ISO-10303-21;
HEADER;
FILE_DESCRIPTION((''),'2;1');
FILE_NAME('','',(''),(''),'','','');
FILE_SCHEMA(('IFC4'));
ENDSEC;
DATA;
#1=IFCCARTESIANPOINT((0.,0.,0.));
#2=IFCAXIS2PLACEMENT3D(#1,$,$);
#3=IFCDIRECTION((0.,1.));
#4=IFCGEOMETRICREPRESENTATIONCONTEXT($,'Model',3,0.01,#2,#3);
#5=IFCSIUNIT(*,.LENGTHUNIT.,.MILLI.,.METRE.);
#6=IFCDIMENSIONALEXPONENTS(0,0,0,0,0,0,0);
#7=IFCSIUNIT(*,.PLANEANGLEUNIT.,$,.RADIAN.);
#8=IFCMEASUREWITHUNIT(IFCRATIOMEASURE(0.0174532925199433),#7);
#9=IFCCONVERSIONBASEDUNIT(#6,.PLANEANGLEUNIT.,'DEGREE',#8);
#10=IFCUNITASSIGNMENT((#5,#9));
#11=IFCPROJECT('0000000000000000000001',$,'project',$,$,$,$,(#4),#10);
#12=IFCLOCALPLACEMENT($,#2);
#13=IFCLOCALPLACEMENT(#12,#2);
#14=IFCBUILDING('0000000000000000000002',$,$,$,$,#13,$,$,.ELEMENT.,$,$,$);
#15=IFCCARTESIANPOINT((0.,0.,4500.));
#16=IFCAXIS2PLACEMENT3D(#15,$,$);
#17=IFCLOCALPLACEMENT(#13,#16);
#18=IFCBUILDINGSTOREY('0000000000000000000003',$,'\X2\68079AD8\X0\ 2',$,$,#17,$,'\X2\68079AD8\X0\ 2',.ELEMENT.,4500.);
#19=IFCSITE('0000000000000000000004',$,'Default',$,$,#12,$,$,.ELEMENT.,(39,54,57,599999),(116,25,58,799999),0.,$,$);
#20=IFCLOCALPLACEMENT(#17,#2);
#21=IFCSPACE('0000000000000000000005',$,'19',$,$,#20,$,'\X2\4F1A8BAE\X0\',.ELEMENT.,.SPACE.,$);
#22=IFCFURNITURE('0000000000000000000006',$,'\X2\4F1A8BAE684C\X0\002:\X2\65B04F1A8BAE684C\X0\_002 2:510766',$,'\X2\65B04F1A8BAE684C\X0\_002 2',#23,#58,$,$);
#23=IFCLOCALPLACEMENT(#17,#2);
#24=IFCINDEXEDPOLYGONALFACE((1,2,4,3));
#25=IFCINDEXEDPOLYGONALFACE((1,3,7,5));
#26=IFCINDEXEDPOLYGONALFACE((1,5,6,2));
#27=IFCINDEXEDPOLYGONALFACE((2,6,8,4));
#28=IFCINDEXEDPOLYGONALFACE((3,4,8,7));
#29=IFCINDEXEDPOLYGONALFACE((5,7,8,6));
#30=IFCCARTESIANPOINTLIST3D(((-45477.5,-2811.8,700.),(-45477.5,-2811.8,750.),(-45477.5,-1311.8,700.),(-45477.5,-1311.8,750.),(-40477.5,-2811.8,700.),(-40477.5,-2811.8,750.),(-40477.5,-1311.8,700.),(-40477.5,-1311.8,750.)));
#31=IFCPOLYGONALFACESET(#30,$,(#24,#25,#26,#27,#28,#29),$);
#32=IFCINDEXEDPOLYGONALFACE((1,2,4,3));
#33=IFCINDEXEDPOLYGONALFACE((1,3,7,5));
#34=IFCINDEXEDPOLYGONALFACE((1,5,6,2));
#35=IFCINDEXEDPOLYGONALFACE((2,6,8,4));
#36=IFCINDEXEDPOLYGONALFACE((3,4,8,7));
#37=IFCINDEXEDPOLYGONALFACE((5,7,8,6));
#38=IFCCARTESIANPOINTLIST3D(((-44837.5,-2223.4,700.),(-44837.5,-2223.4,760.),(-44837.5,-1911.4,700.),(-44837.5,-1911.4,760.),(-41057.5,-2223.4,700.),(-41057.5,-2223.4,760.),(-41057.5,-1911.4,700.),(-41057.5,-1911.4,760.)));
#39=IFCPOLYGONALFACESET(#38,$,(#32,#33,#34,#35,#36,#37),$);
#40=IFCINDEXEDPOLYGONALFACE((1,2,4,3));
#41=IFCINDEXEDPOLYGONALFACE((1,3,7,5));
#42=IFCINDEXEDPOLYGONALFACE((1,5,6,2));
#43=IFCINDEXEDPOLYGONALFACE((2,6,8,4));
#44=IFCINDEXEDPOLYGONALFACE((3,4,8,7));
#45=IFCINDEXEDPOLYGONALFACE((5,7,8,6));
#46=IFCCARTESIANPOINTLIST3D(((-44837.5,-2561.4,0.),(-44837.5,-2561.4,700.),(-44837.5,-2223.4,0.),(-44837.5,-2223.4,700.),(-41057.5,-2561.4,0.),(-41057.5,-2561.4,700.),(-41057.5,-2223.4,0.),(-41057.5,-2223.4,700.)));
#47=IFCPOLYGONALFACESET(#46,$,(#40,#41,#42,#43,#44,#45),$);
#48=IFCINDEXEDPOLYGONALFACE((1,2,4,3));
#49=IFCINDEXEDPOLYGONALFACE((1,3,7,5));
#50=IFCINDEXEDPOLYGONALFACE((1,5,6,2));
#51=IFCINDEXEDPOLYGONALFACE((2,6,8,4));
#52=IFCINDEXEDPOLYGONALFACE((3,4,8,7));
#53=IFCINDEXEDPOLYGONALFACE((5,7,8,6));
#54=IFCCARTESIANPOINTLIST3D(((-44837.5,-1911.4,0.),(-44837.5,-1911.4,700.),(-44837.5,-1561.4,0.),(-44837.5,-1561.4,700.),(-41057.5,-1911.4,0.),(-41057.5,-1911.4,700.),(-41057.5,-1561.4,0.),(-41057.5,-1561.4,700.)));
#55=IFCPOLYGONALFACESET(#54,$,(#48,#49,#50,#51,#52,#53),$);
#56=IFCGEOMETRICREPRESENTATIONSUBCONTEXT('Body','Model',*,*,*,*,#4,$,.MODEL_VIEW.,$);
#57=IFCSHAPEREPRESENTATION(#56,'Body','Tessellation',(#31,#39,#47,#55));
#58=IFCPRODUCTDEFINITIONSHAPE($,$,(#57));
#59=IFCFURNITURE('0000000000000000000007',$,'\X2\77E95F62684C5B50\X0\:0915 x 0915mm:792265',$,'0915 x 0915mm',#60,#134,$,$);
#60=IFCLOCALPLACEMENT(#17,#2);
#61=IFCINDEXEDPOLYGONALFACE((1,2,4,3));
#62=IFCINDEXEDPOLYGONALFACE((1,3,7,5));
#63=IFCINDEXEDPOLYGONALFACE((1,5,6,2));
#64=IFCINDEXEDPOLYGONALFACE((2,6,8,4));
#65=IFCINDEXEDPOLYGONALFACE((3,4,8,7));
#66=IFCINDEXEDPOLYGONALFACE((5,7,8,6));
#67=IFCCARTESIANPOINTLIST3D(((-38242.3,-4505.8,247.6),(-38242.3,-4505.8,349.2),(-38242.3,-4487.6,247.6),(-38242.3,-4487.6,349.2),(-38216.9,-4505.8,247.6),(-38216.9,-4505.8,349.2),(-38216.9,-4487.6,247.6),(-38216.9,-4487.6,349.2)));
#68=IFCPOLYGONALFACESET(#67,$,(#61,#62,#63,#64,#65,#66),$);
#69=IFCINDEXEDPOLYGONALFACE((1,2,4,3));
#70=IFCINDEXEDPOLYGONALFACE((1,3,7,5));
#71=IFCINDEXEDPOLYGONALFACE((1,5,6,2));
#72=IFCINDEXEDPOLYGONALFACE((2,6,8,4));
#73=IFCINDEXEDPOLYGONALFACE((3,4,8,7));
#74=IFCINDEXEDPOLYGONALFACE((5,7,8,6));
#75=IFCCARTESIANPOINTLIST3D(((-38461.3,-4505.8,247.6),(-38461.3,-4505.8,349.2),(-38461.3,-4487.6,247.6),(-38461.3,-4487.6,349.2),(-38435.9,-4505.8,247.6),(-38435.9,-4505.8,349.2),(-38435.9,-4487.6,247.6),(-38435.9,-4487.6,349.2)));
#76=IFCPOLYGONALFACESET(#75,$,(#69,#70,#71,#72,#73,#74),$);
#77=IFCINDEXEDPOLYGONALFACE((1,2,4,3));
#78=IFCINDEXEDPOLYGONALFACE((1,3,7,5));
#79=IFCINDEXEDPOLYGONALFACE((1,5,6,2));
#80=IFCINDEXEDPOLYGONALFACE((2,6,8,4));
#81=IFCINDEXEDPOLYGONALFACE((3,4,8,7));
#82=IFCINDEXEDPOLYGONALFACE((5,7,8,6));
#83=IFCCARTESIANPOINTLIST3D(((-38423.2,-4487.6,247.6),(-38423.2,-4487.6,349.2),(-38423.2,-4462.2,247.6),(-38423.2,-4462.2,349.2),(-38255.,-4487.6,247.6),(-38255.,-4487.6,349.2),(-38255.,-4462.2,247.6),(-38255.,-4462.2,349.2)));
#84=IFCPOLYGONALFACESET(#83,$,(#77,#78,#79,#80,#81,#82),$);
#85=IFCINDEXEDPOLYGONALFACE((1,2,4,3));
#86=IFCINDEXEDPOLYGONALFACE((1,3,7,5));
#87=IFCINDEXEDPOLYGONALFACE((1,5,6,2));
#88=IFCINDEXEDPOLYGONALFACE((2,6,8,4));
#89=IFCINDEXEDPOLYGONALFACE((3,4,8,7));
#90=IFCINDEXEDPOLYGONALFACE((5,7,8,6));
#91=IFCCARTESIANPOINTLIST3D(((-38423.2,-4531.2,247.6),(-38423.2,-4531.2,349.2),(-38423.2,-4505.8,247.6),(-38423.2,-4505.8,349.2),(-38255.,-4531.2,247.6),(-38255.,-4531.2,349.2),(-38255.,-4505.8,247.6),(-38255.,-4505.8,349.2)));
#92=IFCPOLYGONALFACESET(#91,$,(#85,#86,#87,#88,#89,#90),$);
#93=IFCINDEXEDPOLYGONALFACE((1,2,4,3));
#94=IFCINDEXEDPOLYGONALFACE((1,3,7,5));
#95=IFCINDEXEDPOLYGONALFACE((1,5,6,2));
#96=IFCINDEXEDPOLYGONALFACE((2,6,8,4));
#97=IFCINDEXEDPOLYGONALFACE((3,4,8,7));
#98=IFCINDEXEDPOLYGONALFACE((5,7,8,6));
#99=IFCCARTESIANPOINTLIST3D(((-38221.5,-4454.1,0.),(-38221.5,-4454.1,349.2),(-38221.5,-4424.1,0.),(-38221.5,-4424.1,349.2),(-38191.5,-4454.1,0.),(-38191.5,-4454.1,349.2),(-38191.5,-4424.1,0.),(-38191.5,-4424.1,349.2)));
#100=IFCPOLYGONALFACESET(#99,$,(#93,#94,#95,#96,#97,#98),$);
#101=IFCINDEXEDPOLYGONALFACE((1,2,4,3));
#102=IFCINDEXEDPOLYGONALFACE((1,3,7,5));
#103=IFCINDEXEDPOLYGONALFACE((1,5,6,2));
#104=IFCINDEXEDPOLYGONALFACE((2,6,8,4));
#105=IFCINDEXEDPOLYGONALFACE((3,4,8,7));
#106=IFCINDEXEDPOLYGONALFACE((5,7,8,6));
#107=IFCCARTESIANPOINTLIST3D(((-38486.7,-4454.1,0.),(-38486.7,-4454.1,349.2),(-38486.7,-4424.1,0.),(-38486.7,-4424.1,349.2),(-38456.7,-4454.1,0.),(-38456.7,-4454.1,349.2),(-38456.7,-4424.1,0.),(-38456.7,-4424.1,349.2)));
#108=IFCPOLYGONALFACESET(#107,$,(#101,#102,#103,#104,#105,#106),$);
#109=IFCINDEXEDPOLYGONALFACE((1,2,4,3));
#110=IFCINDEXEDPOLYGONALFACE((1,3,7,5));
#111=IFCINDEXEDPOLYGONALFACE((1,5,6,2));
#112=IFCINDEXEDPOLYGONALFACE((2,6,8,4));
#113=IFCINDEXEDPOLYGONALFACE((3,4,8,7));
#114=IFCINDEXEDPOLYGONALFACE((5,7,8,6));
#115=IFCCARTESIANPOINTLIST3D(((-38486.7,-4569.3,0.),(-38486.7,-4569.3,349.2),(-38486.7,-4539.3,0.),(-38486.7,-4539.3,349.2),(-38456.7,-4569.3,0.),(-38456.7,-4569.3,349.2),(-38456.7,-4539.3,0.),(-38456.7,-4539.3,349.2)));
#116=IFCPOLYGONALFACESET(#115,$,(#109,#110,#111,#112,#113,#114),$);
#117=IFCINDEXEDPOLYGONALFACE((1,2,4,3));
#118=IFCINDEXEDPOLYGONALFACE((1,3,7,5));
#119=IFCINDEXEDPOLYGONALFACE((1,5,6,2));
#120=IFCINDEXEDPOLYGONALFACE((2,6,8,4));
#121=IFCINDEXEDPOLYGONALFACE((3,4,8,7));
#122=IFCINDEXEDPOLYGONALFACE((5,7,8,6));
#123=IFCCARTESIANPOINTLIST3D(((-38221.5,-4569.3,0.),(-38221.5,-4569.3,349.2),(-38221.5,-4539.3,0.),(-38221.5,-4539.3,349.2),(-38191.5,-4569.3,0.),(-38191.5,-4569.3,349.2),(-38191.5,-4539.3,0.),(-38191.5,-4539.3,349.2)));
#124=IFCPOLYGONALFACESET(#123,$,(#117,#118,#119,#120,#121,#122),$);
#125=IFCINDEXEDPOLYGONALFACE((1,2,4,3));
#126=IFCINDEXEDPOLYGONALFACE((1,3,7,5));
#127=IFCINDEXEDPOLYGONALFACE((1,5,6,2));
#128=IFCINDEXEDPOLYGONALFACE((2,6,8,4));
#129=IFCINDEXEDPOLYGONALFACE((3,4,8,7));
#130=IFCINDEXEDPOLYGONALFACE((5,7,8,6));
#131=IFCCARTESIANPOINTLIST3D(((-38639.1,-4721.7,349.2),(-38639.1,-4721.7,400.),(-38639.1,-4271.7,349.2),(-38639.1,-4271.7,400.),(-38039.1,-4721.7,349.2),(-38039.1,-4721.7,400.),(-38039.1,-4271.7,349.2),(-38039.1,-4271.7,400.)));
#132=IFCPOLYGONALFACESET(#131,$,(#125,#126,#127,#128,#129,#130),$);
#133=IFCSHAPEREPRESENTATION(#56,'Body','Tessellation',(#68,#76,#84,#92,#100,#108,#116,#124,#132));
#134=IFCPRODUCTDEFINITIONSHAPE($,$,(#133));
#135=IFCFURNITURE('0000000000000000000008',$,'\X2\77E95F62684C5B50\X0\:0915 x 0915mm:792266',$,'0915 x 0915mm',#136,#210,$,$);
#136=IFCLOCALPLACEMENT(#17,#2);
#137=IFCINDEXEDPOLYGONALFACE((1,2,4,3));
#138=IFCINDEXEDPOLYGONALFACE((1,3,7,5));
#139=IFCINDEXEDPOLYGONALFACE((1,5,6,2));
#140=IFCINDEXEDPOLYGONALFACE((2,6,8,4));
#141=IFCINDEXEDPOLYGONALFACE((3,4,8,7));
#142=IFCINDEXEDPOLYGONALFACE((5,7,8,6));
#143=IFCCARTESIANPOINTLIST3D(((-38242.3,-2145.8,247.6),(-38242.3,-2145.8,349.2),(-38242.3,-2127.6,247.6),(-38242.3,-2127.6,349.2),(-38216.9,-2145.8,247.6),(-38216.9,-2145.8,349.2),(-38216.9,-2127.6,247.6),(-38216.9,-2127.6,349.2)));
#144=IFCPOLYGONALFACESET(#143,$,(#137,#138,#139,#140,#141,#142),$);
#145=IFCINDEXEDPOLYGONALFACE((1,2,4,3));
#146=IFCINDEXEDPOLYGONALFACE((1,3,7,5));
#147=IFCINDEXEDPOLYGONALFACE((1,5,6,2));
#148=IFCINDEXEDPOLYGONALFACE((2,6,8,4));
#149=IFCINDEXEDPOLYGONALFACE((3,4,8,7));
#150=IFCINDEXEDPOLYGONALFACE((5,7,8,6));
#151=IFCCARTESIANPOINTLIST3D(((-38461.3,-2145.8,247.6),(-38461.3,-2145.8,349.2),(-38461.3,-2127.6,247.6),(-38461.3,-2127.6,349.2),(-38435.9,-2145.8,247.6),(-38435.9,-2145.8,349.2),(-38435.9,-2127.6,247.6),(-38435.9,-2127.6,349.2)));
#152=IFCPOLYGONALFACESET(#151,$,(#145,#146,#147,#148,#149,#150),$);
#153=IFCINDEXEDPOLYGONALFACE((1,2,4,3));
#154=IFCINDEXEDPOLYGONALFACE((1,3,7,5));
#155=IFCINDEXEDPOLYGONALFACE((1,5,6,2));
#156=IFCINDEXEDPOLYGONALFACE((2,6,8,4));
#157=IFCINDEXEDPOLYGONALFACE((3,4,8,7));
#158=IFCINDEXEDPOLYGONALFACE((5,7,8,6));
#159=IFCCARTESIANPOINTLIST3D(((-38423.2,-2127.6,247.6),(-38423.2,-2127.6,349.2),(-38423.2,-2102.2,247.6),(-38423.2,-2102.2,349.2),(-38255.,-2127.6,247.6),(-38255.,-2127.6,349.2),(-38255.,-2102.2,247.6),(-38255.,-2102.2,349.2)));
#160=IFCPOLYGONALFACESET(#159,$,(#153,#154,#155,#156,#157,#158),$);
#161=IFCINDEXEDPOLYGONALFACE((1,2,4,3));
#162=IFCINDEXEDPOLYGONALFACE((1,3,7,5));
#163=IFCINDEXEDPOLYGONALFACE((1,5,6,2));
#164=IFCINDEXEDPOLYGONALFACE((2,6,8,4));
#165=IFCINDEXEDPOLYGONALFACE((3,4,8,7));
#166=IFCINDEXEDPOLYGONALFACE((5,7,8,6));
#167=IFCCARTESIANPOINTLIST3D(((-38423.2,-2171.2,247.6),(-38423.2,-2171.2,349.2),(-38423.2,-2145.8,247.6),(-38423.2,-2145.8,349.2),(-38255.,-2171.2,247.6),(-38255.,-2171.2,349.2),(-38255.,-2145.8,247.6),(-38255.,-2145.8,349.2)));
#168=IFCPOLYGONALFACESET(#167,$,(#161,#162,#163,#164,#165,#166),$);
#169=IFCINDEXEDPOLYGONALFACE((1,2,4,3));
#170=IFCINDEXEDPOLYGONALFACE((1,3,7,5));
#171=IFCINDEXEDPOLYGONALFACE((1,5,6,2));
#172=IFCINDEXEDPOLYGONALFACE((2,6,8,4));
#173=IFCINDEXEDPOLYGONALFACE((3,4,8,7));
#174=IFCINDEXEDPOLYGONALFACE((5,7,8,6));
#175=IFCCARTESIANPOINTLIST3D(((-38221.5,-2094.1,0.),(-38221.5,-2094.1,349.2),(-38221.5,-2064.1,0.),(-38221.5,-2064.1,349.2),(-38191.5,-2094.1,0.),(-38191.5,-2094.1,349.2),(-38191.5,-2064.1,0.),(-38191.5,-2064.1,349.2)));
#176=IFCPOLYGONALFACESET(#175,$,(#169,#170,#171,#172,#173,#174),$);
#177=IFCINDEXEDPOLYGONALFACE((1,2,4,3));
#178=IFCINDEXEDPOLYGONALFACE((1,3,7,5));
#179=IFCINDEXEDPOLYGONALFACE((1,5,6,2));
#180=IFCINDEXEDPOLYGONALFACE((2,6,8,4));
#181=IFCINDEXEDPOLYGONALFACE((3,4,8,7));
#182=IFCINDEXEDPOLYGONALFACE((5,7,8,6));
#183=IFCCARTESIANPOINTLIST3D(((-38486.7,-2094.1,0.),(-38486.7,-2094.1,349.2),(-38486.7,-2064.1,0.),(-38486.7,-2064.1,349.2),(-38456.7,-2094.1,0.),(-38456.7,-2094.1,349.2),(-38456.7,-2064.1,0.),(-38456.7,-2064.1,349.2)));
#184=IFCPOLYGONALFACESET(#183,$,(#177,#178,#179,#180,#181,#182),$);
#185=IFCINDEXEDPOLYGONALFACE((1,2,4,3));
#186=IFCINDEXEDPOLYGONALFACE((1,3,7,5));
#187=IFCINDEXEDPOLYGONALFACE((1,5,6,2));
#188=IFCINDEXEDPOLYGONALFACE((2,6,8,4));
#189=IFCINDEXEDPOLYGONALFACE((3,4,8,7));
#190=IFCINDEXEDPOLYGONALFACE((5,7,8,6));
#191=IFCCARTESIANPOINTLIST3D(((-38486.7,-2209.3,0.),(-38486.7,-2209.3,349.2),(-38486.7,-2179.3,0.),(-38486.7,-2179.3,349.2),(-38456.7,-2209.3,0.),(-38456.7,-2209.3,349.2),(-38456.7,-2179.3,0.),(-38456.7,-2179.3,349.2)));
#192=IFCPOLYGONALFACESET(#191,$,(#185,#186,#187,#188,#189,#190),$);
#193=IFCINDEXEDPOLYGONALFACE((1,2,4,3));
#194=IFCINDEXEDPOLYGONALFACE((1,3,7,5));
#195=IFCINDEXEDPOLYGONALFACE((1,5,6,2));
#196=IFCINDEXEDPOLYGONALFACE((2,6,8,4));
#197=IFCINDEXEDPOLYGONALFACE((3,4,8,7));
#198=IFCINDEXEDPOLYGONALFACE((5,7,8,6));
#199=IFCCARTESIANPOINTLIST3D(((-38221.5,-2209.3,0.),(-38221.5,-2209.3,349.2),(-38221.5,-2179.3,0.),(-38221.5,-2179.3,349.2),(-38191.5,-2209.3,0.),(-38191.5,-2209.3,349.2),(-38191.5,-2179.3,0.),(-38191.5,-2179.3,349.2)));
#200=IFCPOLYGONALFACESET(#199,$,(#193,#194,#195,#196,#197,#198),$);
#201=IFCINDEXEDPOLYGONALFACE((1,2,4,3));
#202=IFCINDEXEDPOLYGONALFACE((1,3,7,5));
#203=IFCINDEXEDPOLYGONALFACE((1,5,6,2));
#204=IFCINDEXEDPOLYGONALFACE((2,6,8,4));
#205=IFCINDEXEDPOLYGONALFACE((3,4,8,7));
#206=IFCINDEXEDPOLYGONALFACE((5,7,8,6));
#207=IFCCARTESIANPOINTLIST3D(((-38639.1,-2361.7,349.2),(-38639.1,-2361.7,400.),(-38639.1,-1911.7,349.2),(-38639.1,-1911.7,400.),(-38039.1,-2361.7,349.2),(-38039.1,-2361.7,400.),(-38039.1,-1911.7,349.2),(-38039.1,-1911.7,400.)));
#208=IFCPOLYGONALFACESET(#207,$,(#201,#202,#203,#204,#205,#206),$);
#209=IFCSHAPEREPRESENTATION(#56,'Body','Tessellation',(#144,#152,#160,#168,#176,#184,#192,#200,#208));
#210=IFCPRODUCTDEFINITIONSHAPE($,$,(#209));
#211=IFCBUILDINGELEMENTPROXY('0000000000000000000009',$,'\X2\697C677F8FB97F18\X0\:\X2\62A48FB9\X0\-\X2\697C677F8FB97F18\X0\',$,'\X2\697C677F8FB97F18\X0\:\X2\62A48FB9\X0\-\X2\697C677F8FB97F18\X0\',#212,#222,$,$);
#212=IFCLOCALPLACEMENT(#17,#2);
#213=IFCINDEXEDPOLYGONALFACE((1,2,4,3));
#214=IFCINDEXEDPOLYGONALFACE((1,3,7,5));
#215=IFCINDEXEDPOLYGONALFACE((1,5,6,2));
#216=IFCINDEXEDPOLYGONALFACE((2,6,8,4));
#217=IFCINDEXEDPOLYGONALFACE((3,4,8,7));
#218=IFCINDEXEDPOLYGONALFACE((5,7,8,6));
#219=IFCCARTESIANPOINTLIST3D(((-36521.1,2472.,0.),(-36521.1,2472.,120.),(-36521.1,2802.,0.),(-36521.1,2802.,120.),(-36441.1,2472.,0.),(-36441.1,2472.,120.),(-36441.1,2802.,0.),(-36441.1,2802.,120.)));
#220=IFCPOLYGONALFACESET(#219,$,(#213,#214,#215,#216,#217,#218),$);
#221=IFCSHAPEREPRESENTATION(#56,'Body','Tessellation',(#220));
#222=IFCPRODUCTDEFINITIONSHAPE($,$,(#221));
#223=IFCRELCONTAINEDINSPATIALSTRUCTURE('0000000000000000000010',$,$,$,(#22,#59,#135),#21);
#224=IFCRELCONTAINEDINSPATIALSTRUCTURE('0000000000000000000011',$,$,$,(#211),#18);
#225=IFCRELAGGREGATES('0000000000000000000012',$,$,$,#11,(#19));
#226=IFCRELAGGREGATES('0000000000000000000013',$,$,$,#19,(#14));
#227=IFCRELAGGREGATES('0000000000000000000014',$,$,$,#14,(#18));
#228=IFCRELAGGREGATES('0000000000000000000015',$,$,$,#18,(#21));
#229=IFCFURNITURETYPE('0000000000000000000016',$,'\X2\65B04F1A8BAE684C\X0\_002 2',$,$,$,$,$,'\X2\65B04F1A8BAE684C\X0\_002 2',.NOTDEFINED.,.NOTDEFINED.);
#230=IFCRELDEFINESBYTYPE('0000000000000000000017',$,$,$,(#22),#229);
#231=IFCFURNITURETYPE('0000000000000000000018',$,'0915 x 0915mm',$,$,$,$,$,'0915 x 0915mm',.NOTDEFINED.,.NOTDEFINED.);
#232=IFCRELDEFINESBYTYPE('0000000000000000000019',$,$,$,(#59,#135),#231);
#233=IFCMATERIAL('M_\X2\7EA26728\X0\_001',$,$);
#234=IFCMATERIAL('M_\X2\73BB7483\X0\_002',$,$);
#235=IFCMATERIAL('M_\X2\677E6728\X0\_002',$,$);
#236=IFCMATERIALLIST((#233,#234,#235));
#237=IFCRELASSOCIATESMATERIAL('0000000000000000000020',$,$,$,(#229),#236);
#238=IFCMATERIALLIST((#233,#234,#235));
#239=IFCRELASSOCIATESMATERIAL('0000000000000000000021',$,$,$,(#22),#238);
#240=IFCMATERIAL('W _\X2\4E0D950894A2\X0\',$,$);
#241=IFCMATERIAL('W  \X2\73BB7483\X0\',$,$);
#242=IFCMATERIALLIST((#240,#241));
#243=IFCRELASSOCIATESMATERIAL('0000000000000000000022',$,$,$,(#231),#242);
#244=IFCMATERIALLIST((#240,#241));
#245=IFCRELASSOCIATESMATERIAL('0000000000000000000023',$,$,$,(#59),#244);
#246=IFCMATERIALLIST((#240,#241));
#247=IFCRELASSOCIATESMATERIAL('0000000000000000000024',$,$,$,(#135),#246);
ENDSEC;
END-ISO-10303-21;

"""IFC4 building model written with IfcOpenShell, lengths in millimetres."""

from ifc_helpers import new_model, entity, si_unit, converted_unit, direction, frame, frame_2d, origin, origin_2d_with_axis, place, context, subcontext, project, spatial, rectangle, extrude, source, transform, mapped, material, material_list, type_object, type_shapes, element, save


model = new_model("IFC4")

# Units and contexts
model_context = context("Model", 3, precision=0.01, world=origin(), true_north=direction((0.0, 1.0)))
body_context = subcontext(model_context, "Body", "Model", "MODEL_VIEW")
ifc_project = project(units=[si_unit("LENGTHUNIT", "METRE", prefix="MILLI"), converted_unit("PLANEANGLEUNIT", "DEGREE", entity("IfcRatioMeasure", 0.0174532925199433), si_unit("PLANEANGLEUNIT", "RADIAN"), dimensions=[0, 0, 0, 0, 0, 0, 0])], contexts=[model_context])

# Site, building, storey
site_placement = place(None, origin())
site = spatial("IfcSite", under=ifc_project, at=site_placement, Name="Default", CompositionType="ELEMENT", RefLatitude=(39, 54, 57, 599999), RefLongitude=(116, 25, 58, 799999), RefElevation=0.0)
building_placement = place(site_placement, origin())
building = spatial("IfcBuilding", under=site, at=building_placement, CompositionType="ELEMENT")
storey_placement = place(building_placement, frame((0.0, 0.0, 4500.0)))
storey = spatial("IfcBuildingStorey", under=building, at=storey_placement, Name="标高 2", LongName="标高 2", CompositionType="ELEMENT", Elevation=4500.0)

# Shared definitions
space_placement = place(storey_placement, origin())
space = spatial("IfcSpace", under=storey, at=space_placement, Name="19", LongName="会议", CompositionType="ELEMENT", PredefinedType="SPACE")

# Furniture
ifc_material_1 = material(Name="M_红木_001")
ifc_material_2 = material(Name="M_玻璃_002")
ifc_material_3 = material(Name="M_松木_002")
ifc_material_list_1 = material_list([ifc_material_1, ifc_material_2, ifc_material_3])
ifc_material_list_2 = material_list([ifc_material_1, ifc_material_2, ifc_material_3])
furniture_type_1 = type_object("IfcFurnitureType", Name="新会议桌_002 2", ElementType="新会议桌_002 2", AssemblyPlace="NOTDEFINED", PredefinedType="NOTDEFINED", material=ifc_material_list_2)
shared_shape_1 = source(origin(), body_context, "Body", "SweptSolid", [
    extrude(rectangle(XDim=5000.0, YDim=1500.0, at=frame_2d((0.0, 0.0), x_axis=(1.0, 0.0))), frame((0.0, 0.0, 700.0), z_axis=(0.0, 0.0, 1.0), x_axis=(-1.0, 0.0, 0.0)), (0.0, 0.0, 1.0), 50.0),
    extrude(rectangle(XDim=3780.0, YDim=312.0, at=origin_2d_with_axis()), frame((30.0, -5.6, 700.0), z_axis=(0.0, 0.0, 1.0), x_axis=(-1.0, 0.0, 0.0)), (0.0, 0.0, 1.0), 60.0),
    extrude(rectangle(XDim=338.0, YDim=3780.0, at=origin_2d_with_axis()), frame((30.0, -330.6, 0.0), z_axis=(0.0, 0.0, 1.0), x_axis=(0.0, 1.0, 0.0)), (0.0, 0.0, 1.0), 700.0),
    extrude(rectangle(XDim=350.0, YDim=3780.0, at=origin_2d_with_axis()), frame((30.0, 325.4, 0.0), z_axis=(0.0, 0.0, 1.0), x_axis=(0.0, -1.0, 0.0)), (0.0, 0.0, 1.0), 700.0),
])
type_shapes(furniture_type_1, [shared_shape_1])
furniture_1_placement = place(space_placement, frame((-42977.5, -2061.8, 0.0)))
element("IfcFurniture", 1, at=furniture_1_placement, inside=space, type_object=furniture_type_1, material=ifc_material_list_1, Name="会议桌002:新会议桌_002 2:510766", ObjectType="新会议桌_002 2", context=body_context, shape_type="MappedRepresentation", body=[
    mapped(shared_shape_1, transform((0.0, 0.0, 0.0), scale=1.0)),
])
ifc_material_4 = material(Name="W _不锈钢")
ifc_material_5 = material(Name="W  玻璃")
ifc_material_list_3 = material_list([ifc_material_4, ifc_material_5])
ifc_material_list_4 = material_list([ifc_material_4, ifc_material_5])
furniture_type_2 = type_object("IfcFurnitureType", Name="0915 x 0915mm", ElementType="0915 x 0915mm", AssemblyPlace="NOTDEFINED", PredefinedType="NOTDEFINED", material=ifc_material_list_4)
shared_shape_2 = source(origin(), body_context, "Body", "SweptSolid", [
    extrude(rectangle(XDim=25.4, YDim=18.2, at=origin_2d_with_axis()), frame((109.5, 0.0, 247.6)), (0.0, 0.0, 1.0), 101.6),
    extrude(rectangle(XDim=18.2, YDim=25.4, at=origin_2d_with_axis()), frame((-109.5, 0.0, 247.6), z_axis=(0.0, 0.0, 1.0), x_axis=(0.0, 1.0, 0.0)), (0.0, 0.0, 1.0), 101.6),
    extrude(rectangle(XDim=168.2, YDim=25.4, at=frame_2d((0.0, 0.0), x_axis=(1.0, 0.0))), frame((0.0, 21.8, 247.6), z_axis=(0.0, 0.0, 1.0), x_axis=(-1.0, 0.0, 0.0)), (0.0, 0.0, 1.0), 101.6),
    extrude(rectangle(XDim=25.4, YDim=168.2, at=origin_2d_with_axis()), frame((0.0, -21.8, 247.6), z_axis=(0.0, 0.0, 1.0), x_axis=(0.0, 1.0, 0.0)), (0.0, 0.0, 1.0), 101.6),
    extrude(rectangle(XDim=30.0, YDim=30.0, at=origin_2d_with_axis()), frame((132.6, 57.6, 0.0), z_axis=(0.0, 0.0, 1.0), x_axis=(0.0, -1.0, 0.0)), (0.0, 0.0, 1.0), 349.2),
    extrude(rectangle(XDim=30.0, YDim=30.0, at=frame_2d((0.0, 0.0), x_axis=(1.0, 0.0))), frame((-132.6, 57.6, 0.0), z_axis=(0.0, 0.0, 1.0), x_axis=(-1.0, 0.0, 0.0)), (0.0, 0.0, 1.0), 349.2),
    extrude(rectangle(XDim=30.0, YDim=30.0, at=frame_2d((0.0, 0.0), x_axis=(1.0, 0.0))), frame((-132.6, -57.6, 0.0), z_axis=(0.0, 0.0, 1.0), x_axis=(0.0, 1.0, 0.0)), (0.0, 0.0, 1.0), 349.2),
    extrude(rectangle(XDim=30.0, YDim=30.0, at=frame_2d((0.0, 0.0), x_axis=(1.0, 0.0))), frame((132.6, -57.6, 0.0)), (0.0, 0.0, 1.0), 349.2),
    extrude(rectangle(XDim=600.0, YDim=450.0, at=origin_2d_with_axis()), frame((0.0, 0.0, 349.2), z_axis=(0.0, 0.0, 1.0), x_axis=(-1.0, 0.0, 0.0)), (0.0, 0.0, 1.0), 50.8),
])
type_shapes(furniture_type_2, [shared_shape_2])
furniture_2_placement = place(space_placement, frame((-38339.1, -4496.7, 0.0)))
element("IfcFurniture", 2, at=furniture_2_placement, inside=space, type_object=furniture_type_2, material=ifc_material_list_3, Name="矩形桌子:0915 x 0915mm:792265", ObjectType="0915 x 0915mm", context=body_context, shape_type="MappedRepresentation", body=[
    mapped(shared_shape_2, transform((0.0, 0.0, 0.0), scale=1.0)),
])
ifc_material_list_5 = material_list([ifc_material_4, ifc_material_5])
furniture_3_placement = place(space_placement, frame((-38339.1, -2136.7, 0.0)))
element("IfcFurniture", 3, at=furniture_3_placement, inside=space, type_object=furniture_type_2, material=ifc_material_list_5, Name="矩形桌子:0915 x 0915mm:792266", ObjectType="0915 x 0915mm", context=body_context, shape_type="MappedRepresentation", body=[
    mapped(shared_shape_2, transform((0.0, 0.0, 0.0), scale=1.0)),
])

# Building element proxy
proxy_placement = place(storey_placement, frame((-36521.1, 2472.0, 0.0)))
element("IfcBuildingElementProxy", 4, at=proxy_placement, inside=storey, Name="楼板边缘:护边-楼板边缘", ObjectType="楼板边缘:护边-楼板边缘", context=body_context, shape_type="SweptSolid", body=[
    extrude(rectangle(XDim=330.0, YDim=80.0, at=origin_2d_with_axis()), frame((40.0, 165.0, 0.0), z_axis=(0.0, 0.0, 1.0), x_axis=(0.0, -1.0, 0.0)), (0.0, 0.0, 1.0), 120.0),
])

save(model, "model.ifc")
